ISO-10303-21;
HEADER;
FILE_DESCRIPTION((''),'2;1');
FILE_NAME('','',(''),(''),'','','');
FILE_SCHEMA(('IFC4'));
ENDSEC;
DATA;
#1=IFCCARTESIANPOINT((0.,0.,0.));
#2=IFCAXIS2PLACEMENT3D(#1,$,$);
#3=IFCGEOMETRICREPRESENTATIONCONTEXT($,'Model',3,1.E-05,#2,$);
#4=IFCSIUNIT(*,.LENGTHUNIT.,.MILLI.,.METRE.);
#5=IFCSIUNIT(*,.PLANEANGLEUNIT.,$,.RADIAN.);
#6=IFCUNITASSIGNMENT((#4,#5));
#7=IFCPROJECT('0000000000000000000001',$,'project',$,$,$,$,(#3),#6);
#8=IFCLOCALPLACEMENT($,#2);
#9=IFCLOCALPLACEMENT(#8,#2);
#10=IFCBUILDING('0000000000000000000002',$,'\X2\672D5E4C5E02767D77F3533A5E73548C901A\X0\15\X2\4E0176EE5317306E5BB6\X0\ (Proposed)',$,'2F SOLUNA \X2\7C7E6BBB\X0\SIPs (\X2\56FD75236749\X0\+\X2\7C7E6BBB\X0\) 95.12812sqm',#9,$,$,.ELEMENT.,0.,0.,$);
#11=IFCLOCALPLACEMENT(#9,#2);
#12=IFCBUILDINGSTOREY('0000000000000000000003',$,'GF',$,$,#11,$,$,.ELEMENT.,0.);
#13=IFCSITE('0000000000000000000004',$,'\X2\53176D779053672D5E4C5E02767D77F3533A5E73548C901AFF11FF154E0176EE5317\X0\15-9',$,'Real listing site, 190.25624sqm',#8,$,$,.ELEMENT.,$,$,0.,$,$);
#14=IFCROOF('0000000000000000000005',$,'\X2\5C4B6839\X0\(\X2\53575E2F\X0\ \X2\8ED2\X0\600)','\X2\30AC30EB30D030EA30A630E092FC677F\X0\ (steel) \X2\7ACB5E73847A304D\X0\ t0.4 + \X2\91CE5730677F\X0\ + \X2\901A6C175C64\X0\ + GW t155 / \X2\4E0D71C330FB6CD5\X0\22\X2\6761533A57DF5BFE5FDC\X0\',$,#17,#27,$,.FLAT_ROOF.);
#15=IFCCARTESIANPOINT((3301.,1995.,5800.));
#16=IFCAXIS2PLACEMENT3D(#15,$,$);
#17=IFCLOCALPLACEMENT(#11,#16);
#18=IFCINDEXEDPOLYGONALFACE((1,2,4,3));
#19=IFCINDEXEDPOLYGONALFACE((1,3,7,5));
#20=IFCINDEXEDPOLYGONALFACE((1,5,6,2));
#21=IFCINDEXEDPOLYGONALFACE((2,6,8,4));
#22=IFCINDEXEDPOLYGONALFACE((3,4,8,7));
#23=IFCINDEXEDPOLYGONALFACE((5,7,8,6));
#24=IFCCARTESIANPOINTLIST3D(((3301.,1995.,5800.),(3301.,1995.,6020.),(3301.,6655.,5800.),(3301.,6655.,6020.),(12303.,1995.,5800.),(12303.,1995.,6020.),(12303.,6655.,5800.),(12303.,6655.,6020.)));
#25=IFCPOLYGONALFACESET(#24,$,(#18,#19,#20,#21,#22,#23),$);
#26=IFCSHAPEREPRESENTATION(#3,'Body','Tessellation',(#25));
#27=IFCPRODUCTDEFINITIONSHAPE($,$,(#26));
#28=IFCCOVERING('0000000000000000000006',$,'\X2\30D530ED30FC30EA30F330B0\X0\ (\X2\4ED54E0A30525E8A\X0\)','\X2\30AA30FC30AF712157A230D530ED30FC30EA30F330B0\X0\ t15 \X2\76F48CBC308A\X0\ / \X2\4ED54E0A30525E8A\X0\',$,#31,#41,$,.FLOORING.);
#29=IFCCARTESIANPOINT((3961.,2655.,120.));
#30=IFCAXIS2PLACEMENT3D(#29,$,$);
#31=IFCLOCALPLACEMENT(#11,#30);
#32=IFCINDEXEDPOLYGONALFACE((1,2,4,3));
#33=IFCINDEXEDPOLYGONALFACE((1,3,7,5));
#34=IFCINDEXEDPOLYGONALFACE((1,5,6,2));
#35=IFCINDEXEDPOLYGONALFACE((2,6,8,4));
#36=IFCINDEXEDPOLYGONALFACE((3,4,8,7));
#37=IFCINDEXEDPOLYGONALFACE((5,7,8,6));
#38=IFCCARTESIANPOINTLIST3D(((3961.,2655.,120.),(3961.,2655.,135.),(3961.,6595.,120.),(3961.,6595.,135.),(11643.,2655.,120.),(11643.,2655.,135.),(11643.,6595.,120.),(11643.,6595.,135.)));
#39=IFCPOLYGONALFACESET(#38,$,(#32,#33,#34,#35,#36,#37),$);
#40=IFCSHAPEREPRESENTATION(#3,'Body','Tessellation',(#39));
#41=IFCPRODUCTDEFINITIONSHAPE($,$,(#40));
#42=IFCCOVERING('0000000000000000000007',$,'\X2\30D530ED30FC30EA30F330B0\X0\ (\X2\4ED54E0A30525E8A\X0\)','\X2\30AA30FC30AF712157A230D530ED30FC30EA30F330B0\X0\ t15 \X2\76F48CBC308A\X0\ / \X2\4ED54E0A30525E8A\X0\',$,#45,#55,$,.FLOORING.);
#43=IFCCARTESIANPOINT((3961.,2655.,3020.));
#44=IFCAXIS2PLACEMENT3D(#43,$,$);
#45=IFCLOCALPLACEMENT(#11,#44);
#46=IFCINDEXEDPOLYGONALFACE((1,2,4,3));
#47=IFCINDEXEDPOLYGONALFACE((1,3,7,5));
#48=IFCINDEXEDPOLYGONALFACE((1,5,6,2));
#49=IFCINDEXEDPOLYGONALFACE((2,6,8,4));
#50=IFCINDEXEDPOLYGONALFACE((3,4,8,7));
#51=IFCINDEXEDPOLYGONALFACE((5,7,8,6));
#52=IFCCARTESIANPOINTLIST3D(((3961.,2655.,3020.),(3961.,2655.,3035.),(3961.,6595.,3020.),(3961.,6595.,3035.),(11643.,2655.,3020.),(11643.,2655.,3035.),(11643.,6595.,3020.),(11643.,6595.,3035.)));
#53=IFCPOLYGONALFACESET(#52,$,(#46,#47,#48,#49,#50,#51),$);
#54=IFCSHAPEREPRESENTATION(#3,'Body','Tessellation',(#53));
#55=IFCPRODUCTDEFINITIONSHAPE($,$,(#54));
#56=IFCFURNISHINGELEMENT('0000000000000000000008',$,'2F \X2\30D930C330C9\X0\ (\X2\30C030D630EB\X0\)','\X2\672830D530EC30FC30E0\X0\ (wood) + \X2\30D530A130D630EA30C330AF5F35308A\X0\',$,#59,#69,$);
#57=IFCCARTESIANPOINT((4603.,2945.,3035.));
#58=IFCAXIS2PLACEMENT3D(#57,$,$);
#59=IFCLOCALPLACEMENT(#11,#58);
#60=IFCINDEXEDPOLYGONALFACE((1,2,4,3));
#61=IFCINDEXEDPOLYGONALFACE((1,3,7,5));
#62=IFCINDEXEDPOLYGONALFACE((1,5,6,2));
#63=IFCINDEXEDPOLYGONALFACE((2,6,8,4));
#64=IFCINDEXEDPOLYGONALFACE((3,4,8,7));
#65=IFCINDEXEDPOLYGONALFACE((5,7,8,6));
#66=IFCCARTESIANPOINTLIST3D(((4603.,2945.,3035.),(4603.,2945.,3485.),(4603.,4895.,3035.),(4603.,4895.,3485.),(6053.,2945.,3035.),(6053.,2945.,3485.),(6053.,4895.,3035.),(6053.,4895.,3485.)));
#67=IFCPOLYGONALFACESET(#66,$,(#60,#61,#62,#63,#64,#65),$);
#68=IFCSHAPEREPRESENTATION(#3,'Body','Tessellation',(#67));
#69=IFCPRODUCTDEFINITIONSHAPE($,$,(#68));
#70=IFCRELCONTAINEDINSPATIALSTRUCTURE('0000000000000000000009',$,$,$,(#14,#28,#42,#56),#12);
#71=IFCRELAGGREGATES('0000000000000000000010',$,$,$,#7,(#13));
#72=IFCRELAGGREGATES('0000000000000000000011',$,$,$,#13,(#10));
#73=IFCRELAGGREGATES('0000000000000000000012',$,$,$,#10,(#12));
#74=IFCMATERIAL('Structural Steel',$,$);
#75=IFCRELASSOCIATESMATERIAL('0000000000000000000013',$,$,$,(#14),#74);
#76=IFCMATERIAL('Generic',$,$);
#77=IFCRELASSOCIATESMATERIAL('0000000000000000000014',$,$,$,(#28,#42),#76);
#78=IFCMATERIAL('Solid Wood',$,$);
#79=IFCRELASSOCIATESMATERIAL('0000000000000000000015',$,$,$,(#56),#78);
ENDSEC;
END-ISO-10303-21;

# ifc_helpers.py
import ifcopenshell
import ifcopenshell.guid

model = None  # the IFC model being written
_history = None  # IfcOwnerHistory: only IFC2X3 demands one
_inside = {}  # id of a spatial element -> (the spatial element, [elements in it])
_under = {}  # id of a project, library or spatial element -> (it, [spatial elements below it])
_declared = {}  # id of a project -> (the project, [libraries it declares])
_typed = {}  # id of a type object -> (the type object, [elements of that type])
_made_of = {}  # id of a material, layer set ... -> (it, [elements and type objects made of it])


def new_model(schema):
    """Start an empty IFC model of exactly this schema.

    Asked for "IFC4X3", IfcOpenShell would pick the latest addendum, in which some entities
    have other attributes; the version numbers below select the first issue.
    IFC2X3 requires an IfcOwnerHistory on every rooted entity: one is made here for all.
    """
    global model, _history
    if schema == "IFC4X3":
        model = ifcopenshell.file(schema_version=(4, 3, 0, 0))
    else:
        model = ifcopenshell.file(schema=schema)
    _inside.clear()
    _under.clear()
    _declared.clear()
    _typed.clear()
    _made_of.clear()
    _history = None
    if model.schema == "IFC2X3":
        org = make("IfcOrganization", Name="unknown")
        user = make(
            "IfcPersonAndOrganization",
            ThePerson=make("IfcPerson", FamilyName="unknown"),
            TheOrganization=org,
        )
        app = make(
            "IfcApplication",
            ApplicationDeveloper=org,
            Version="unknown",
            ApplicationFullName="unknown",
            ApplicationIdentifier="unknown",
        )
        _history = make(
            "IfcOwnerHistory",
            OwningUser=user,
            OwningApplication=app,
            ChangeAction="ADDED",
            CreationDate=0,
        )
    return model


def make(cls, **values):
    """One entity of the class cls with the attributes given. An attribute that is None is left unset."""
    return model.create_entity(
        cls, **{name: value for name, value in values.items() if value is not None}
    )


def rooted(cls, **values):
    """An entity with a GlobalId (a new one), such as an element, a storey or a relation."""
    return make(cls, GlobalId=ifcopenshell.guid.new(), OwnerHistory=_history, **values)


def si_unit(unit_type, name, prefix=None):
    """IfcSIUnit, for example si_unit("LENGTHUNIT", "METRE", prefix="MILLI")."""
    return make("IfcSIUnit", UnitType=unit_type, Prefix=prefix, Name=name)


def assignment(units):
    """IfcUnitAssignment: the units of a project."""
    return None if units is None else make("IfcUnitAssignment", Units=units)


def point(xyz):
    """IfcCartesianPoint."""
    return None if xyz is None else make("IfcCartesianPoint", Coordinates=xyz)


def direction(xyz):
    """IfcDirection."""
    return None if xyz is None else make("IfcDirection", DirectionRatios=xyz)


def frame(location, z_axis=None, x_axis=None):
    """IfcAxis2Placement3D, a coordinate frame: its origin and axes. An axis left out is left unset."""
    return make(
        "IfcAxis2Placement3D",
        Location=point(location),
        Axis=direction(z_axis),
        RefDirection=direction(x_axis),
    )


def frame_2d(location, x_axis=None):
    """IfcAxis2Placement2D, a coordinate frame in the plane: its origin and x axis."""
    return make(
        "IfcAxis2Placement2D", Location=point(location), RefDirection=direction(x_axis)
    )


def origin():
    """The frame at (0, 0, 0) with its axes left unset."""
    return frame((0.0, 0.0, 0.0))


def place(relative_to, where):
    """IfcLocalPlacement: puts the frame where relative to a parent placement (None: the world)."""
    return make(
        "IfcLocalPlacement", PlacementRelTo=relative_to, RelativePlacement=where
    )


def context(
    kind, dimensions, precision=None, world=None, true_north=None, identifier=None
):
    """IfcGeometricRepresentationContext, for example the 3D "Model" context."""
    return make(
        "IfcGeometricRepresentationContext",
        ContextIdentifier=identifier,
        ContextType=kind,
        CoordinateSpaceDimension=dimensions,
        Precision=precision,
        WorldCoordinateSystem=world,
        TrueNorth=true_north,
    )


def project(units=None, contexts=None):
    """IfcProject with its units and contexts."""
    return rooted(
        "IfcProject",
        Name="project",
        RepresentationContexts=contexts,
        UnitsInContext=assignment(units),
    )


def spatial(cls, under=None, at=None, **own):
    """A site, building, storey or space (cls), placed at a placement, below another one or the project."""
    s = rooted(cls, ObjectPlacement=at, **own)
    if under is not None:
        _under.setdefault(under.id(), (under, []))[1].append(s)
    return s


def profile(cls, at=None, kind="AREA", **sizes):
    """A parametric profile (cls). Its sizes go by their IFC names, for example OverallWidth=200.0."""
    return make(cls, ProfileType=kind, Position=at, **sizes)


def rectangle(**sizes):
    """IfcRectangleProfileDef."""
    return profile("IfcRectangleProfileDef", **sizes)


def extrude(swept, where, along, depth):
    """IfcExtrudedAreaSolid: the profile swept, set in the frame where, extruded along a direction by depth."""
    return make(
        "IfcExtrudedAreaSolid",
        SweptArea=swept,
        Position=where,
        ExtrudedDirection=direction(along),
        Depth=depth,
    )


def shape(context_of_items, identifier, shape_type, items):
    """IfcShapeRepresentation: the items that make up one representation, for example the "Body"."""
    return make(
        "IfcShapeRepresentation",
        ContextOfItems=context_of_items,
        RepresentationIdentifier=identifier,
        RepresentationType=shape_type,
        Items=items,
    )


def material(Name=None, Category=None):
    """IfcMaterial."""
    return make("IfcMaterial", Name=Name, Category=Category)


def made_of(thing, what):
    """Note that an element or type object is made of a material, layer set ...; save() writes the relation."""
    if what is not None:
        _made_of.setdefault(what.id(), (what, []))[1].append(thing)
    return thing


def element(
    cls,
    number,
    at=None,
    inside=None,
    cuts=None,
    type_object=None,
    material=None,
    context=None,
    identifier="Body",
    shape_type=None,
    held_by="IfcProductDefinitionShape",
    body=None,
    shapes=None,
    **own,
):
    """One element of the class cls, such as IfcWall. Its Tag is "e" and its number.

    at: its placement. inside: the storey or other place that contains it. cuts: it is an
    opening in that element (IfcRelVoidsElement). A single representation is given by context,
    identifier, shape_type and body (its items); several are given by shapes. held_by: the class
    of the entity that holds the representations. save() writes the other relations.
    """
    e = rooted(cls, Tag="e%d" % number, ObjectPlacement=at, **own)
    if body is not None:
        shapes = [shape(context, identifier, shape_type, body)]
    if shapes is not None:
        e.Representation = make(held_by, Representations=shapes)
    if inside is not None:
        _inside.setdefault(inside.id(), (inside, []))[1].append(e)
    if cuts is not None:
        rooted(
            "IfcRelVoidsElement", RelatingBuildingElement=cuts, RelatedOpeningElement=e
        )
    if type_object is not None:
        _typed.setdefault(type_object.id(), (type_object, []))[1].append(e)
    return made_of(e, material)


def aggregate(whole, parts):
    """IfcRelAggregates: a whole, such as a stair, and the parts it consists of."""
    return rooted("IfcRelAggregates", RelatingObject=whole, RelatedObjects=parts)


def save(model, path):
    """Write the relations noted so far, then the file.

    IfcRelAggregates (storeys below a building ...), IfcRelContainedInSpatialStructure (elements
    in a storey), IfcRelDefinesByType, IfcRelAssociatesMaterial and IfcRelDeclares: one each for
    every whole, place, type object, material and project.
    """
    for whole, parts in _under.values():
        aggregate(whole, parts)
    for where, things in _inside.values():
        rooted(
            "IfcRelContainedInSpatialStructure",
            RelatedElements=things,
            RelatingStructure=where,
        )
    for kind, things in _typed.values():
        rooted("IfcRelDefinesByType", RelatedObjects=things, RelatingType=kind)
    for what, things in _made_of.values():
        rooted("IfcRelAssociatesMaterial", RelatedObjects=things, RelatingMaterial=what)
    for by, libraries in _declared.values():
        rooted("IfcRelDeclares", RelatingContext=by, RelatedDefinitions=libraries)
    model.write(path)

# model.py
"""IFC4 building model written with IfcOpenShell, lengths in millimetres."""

from ifc_helpers import new_model, si_unit, frame, frame_2d, origin, place, context, project, spatial, rectangle, extrude, material, element, save


model = new_model("IFC4")

# Units and contexts
model_context = context("Model", 3, precision=1e-05, world=origin())
ifc_project = project(units=[si_unit("LENGTHUNIT", "METRE", prefix="MILLI"), si_unit("PLANEANGLEUNIT", "RADIAN")], contexts=[model_context])

# Site, building, storey
site_placement = place(None, origin())
site = spatial("IfcSite", under=ifc_project, at=site_placement, Name="北海道札幌市白石区平和通１５丁目北15-9", ObjectType="Real listing site, 190.25624sqm", CompositionType="ELEMENT", RefElevation=0.0)
building_placement = place(site_placement, origin())
building = spatial("IfcBuilding", under=site, at=building_placement, Name="札幌市白石区平和通15丁目北の家 (Proposed)", ObjectType="2F SOLUNA 籾殻SIPs (国産杉+籾殻) 95.12812sqm", CompositionType="ELEMENT", ElevationOfRefHeight=0.0, ElevationOfTerrain=0.0)
storey_placement = place(building_placement, origin())
storey = spatial("IfcBuildingStorey", under=building, at=storey_placement, Name="GF", CompositionType="ELEMENT", Elevation=0.0)

# Shared definitions
ifc_material_1 = material(Name="Solid Wood")

# Roof
ifc_material_2 = material(Name="Structural Steel")
for number, where, name in (
    (1, (3301.0, 1995.0, 5800.0), "屋根(南帯 軒600)"),
):
    element("IfcRoof", number, at=place(storey_placement, frame(where)), inside=storey, material=ifc_material_2, Name=name, Description="ガルバリウム鋼板 (steel) 立平葺き t0.4 + 野地板 + 通気層 + GW t155 / 不燃・法22条区域対応", PredefinedType="FLAT_ROOF", context=model_context, shape_type="SweptSolid", body=[
        extrude(rectangle(XDim=9002.0, YDim=4660.0, at=frame_2d((4501.0, 2330.0))), frame((3301.0, 1995.0, 5800.0)), (0.0, 0.0, 1.0), 220.0),
    ])

# Coverings
ifc_material_3 = material(Name="Generic")
covering_1_placement = place(storey_placement, frame((3961.0, 2655.0, 120.0)))
element("IfcCovering", 2, at=covering_1_placement, inside=storey, material=ifc_material_3, Name="フローリング (仕上げ床)", Description="オーク無垢フローリング t15 直貼り / 仕上げ床", PredefinedType="FLOORING", context=model_context, shape_type="SweptSolid", body=[
    extrude(rectangle(XDim=7682.0, YDim=3940.0, at=frame_2d((3841.0, 1970.0))), frame((3961.0, 2655.0, 120.0)), (0.0, 0.0, 1.0), 15.0),
])
covering_2_placement = place(storey_placement, frame((3961.0, 2655.0, 3020.0)))
element("IfcCovering", 3, at=covering_2_placement, inside=storey, material=ifc_material_3, Name="フローリング (仕上げ床)", Description="オーク無垢フローリング t15 直貼り / 仕上げ床", PredefinedType="FLOORING", context=model_context, shape_type="SweptSolid", body=[
    extrude(rectangle(XDim=7682.0, YDim=3940.0, at=frame_2d((3841.0, 1970.0))), frame((3961.0, 2655.0, 3020.0)), (0.0, 0.0, 1.0), 15.0),
])

# Furnishing element
furnishing_placement = place(storey_placement, frame((4603.0, 2945.0, 3035.0)))
element("IfcFurnishingElement", 4, at=furnishing_placement, inside=storey, material=ifc_material_1, Name="2F ベッド (ダブル)", Description="木フレーム (wood) + ファブリック張り", context=model_context, shape_type="SweptSolid", body=[
    extrude(rectangle(XDim=1450.0, YDim=1950.0, at=frame_2d((725.0, 975.0))), frame((4603.0, 2945.0, 3035.0)), (0.0, 0.0, 1.0), 450.0),
])

save(model, "model.ifc")
